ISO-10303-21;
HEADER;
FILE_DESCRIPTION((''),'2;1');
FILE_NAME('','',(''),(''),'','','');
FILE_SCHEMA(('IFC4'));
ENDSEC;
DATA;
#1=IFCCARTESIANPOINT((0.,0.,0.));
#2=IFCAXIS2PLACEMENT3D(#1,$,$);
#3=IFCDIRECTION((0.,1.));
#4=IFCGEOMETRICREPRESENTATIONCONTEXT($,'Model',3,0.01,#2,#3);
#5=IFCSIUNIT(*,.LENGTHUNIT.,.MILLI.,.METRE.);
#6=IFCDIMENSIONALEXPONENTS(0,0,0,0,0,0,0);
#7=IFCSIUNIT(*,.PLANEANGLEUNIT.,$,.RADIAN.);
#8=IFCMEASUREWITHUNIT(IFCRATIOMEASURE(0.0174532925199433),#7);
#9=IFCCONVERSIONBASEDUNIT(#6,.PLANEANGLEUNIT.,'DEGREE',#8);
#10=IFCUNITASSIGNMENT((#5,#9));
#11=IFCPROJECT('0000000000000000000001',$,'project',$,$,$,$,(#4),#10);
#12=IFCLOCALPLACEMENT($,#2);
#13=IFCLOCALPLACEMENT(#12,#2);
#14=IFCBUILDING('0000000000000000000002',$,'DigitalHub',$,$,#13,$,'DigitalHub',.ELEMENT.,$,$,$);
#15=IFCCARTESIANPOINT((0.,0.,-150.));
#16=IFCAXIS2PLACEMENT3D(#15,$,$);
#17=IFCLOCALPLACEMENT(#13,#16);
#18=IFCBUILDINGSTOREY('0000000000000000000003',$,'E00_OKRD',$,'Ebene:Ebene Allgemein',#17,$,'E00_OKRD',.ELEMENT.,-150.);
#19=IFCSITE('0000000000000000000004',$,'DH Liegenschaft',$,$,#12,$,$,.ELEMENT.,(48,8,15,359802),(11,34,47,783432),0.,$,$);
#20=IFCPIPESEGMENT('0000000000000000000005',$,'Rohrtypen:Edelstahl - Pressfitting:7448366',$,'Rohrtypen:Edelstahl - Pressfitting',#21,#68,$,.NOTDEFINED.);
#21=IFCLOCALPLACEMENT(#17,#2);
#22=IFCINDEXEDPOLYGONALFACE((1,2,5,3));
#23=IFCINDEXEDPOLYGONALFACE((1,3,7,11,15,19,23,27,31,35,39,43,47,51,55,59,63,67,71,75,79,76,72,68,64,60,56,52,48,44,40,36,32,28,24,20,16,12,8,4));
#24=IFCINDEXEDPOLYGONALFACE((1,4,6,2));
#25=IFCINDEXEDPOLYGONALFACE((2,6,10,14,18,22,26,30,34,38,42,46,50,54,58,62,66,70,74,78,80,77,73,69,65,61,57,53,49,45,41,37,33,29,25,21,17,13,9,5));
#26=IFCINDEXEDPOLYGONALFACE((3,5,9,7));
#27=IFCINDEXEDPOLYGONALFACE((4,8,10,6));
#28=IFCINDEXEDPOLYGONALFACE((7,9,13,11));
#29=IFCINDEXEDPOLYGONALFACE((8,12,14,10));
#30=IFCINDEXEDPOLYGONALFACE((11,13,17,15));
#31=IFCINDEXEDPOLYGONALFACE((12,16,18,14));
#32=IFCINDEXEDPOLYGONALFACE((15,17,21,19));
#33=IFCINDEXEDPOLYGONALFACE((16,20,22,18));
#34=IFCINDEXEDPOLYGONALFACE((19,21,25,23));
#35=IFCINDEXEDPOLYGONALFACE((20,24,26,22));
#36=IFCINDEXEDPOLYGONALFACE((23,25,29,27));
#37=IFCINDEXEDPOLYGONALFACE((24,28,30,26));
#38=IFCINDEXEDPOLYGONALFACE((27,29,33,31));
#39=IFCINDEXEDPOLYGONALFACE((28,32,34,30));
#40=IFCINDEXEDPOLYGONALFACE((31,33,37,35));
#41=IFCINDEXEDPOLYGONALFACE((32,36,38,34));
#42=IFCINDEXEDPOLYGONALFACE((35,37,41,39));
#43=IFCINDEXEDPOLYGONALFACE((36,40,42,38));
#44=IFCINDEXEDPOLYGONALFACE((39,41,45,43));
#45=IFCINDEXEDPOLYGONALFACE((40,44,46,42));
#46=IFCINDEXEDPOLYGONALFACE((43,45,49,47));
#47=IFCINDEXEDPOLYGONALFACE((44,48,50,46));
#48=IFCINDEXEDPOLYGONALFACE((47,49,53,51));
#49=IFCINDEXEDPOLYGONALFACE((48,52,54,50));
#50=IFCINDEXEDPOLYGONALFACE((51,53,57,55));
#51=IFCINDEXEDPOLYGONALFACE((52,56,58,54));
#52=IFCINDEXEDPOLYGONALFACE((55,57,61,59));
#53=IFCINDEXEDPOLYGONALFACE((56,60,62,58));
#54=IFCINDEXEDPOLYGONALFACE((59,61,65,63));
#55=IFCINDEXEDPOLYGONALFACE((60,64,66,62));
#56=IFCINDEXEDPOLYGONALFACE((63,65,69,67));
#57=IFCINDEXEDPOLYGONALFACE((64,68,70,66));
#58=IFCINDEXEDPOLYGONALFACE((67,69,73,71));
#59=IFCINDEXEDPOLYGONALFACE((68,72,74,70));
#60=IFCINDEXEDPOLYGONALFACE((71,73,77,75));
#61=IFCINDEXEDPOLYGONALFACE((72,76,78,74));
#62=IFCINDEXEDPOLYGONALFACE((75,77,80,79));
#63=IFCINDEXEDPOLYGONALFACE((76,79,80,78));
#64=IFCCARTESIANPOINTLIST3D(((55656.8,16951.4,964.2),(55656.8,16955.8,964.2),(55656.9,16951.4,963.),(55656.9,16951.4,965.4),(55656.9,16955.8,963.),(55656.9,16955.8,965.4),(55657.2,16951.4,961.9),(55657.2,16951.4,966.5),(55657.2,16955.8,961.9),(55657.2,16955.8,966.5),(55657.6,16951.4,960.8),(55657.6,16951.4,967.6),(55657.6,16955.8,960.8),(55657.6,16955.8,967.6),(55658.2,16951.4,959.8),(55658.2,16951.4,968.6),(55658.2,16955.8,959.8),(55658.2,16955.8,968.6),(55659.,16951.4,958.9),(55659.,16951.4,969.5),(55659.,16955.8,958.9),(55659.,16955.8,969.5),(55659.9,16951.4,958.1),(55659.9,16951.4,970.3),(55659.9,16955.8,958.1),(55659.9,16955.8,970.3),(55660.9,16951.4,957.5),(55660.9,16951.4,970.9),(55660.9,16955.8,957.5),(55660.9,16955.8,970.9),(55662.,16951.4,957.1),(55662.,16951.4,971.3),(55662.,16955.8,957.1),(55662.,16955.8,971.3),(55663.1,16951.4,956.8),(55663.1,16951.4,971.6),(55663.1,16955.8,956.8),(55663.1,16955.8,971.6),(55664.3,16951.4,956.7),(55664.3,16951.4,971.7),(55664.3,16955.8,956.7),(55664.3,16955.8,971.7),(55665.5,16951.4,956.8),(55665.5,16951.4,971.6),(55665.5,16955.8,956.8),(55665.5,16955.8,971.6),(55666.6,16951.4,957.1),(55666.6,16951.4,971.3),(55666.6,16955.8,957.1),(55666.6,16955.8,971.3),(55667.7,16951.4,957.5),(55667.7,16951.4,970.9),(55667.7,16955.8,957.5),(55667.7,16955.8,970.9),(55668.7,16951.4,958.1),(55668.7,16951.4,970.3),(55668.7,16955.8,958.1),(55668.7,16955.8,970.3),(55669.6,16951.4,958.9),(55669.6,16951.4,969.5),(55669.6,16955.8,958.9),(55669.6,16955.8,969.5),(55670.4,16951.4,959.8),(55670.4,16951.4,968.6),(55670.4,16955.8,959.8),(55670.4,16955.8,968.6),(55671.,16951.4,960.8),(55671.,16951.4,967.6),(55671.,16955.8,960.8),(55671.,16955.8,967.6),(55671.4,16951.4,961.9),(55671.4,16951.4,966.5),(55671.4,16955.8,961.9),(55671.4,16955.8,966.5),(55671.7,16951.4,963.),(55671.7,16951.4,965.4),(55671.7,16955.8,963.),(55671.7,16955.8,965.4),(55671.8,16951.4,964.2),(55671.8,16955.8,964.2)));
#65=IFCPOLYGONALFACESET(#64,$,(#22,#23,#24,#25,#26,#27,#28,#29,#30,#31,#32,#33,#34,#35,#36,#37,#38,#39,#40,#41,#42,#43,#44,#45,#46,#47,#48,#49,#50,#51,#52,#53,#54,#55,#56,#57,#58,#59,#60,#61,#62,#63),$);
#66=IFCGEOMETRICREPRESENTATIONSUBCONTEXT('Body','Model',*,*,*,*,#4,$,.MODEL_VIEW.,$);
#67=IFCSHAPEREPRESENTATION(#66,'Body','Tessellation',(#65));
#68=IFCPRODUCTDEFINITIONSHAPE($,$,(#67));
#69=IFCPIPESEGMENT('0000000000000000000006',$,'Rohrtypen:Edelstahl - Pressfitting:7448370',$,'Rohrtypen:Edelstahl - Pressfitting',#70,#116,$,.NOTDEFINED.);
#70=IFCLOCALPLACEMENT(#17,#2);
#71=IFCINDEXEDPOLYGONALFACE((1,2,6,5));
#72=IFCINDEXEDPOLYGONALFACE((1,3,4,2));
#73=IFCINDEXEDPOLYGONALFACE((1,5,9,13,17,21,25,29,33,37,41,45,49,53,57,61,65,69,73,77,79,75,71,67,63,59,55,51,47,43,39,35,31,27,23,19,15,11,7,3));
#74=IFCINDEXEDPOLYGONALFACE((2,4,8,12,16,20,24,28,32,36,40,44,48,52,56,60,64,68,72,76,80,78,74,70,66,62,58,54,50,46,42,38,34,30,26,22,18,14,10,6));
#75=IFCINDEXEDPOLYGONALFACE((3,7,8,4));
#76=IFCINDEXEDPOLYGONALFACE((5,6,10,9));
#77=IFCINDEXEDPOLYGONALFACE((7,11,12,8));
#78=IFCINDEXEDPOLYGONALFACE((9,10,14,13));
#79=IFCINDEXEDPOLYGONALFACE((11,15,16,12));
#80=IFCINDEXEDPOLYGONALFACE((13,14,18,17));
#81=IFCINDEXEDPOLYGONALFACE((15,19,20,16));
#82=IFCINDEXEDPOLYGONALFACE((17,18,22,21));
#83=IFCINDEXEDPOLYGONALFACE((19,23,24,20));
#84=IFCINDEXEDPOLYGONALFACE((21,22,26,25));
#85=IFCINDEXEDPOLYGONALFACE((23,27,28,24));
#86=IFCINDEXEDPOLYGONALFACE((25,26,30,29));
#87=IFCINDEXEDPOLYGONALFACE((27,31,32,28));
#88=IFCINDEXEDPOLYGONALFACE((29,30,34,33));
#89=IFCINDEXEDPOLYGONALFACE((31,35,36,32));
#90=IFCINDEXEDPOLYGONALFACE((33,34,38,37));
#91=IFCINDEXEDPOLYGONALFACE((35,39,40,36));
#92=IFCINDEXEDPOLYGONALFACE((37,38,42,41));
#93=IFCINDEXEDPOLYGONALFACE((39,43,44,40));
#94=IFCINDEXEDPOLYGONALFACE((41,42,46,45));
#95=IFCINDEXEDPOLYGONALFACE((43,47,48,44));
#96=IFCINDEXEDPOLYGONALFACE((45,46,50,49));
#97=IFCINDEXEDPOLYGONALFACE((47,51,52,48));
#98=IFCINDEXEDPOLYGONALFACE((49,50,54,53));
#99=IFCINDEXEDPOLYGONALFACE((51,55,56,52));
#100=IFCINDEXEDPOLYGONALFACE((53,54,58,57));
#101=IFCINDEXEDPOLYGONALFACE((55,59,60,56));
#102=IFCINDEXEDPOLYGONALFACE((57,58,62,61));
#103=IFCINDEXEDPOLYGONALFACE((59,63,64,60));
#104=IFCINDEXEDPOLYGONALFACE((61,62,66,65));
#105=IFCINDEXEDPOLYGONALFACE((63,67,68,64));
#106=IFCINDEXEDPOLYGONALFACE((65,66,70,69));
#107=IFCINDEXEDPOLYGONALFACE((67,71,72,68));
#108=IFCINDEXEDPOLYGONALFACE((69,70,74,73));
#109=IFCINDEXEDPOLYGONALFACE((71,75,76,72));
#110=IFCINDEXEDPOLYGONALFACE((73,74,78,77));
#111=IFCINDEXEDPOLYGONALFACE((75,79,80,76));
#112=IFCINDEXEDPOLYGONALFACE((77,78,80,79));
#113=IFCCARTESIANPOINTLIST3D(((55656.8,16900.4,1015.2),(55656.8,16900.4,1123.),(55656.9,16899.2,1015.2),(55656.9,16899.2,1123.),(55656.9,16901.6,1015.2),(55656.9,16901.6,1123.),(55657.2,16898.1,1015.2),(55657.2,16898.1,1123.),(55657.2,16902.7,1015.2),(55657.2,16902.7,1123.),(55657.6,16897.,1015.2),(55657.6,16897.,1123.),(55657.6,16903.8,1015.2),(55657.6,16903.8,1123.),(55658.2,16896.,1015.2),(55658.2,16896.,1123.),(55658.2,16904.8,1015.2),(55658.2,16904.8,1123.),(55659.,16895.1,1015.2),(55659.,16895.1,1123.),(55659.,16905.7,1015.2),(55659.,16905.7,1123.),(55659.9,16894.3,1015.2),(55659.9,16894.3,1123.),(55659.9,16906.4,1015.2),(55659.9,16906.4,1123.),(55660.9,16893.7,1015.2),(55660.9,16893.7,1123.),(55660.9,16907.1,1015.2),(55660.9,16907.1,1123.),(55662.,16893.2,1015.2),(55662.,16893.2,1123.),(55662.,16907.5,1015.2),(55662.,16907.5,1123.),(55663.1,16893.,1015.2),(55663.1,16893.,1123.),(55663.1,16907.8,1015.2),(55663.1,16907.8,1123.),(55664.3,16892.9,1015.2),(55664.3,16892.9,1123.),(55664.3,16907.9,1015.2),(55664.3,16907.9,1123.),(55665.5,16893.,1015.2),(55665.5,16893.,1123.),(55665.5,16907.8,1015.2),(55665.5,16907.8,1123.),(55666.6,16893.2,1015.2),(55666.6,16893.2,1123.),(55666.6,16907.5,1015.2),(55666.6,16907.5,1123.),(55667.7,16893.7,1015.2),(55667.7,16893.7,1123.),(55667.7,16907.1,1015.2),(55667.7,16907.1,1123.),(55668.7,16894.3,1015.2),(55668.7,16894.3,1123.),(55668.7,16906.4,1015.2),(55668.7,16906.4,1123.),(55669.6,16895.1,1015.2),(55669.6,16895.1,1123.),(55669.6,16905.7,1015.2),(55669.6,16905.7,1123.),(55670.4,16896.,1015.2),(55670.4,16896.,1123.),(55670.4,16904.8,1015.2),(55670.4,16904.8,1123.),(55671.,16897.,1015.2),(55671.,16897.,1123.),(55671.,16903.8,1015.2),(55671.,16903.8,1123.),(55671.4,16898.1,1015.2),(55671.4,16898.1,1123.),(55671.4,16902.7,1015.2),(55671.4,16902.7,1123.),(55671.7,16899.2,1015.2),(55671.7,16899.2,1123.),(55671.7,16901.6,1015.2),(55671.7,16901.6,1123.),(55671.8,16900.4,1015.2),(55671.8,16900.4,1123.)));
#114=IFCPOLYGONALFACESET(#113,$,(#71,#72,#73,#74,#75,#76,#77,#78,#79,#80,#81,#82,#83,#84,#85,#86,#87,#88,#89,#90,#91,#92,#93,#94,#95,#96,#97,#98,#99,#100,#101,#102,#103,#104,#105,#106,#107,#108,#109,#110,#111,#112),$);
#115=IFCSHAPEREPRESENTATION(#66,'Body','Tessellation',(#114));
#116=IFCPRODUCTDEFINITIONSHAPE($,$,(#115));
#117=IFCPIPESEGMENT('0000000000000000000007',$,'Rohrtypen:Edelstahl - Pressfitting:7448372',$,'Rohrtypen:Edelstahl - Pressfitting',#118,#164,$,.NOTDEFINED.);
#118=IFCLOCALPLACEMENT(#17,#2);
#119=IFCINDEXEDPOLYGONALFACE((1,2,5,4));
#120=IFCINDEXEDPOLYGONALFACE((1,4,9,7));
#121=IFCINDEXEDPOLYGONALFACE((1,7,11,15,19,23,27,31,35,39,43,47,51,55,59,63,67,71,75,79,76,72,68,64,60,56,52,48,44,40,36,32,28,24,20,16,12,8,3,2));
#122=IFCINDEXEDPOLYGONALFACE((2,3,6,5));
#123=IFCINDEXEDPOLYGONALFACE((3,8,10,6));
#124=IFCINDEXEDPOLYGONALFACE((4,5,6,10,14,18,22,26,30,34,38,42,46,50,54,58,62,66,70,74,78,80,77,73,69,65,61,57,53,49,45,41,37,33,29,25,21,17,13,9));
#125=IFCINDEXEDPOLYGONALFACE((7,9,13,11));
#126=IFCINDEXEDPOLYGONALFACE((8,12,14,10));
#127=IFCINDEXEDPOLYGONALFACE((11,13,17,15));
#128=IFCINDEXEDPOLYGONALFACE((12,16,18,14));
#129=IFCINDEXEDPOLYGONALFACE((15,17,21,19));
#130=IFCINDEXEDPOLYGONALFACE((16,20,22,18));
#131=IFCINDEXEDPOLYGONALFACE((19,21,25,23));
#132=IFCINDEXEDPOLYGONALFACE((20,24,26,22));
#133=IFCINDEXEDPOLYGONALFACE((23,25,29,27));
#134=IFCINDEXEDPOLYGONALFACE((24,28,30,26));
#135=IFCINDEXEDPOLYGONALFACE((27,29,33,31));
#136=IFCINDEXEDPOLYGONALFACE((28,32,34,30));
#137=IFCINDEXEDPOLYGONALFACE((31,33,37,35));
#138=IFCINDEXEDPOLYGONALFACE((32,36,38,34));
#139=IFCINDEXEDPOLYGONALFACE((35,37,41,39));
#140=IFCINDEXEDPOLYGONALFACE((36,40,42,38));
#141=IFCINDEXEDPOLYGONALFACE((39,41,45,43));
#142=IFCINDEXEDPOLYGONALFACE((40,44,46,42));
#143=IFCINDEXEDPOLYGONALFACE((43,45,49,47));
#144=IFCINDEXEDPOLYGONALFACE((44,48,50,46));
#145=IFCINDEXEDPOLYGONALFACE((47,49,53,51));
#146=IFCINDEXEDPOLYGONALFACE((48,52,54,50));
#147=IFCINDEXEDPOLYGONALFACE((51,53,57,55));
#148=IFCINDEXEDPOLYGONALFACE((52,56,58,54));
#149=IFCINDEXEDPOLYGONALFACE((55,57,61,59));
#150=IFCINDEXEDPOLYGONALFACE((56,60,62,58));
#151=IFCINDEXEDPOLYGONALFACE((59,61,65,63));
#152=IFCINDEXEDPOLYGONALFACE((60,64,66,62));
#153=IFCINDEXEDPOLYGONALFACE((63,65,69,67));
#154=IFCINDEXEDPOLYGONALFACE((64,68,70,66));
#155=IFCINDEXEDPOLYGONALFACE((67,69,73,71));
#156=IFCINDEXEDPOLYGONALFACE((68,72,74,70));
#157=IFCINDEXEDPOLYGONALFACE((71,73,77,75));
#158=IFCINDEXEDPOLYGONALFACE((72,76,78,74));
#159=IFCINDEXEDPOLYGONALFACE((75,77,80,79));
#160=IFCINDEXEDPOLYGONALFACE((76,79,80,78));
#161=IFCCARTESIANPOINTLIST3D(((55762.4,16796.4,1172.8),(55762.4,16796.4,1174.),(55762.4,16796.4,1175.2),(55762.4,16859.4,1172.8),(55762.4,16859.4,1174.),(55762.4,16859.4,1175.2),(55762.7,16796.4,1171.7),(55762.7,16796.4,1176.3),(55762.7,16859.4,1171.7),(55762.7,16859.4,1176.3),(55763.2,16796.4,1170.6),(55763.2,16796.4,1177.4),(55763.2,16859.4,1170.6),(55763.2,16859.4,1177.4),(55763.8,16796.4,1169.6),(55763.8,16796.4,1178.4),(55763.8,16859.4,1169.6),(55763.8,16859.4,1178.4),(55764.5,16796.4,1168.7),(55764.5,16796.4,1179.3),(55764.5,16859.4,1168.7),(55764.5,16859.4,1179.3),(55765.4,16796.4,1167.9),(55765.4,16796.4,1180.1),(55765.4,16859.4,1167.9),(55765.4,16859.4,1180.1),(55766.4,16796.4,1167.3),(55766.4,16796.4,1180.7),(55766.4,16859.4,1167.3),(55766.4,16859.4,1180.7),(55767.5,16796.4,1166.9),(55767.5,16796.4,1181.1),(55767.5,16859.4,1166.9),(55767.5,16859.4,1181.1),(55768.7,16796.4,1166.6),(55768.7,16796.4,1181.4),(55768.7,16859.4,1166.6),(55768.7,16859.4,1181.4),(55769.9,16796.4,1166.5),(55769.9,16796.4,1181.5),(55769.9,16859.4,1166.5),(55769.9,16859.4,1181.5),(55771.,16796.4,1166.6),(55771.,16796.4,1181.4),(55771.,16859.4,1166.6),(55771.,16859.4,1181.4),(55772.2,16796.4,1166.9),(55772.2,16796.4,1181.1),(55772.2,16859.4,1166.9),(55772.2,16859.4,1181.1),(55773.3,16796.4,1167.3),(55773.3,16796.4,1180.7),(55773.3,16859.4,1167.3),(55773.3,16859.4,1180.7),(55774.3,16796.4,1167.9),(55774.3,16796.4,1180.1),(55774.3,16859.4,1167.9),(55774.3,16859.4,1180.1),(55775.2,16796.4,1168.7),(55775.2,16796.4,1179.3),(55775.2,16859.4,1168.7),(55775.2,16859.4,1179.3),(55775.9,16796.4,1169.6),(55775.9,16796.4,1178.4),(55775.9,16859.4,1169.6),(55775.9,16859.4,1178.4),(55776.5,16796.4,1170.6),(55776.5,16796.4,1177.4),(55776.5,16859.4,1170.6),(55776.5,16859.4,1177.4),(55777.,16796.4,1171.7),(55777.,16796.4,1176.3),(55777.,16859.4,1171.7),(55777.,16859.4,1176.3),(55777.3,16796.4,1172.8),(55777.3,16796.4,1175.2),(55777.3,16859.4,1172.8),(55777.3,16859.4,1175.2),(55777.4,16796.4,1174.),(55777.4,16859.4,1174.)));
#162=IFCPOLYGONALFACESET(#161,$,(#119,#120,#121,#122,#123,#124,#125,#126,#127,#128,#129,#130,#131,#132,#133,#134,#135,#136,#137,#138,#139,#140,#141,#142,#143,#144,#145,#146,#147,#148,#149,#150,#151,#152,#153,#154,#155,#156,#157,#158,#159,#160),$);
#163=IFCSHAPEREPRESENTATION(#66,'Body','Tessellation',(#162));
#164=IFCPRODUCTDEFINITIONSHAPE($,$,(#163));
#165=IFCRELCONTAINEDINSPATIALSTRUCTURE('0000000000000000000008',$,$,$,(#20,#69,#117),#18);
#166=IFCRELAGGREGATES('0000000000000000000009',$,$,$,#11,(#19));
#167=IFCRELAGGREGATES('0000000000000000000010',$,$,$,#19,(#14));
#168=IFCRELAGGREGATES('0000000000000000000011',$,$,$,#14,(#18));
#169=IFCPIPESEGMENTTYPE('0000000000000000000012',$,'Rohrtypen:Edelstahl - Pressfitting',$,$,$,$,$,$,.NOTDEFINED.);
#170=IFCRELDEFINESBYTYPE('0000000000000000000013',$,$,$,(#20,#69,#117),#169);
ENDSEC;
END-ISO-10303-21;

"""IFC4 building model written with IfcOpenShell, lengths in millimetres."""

from ifc_helpers import new_model, entity, si_unit, converted_unit, direction, frame, origin, place, context, subcontext, project, spatial, indexed_curve, outline, extrude, type_object, element, save


model = new_model("IFC4")

# Units and contexts
model_context = context("Model", 3, precision=0.01, world=origin(), true_north=direction((0.0, 1.0)))
body_context = subcontext(model_context, "Body", "Model", "MODEL_VIEW")
ifc_project = project(units=[si_unit("LENGTHUNIT", "METRE", prefix="MILLI"), converted_unit("PLANEANGLEUNIT", "DEGREE", entity("IfcRatioMeasure", 0.0174532925199433), si_unit("PLANEANGLEUNIT", "RADIAN"), dimensions=[0, 0, 0, 0, 0, 0, 0])], contexts=[model_context])

# Site, building, storey
site_placement = place(None, origin())
site = spatial("IfcSite", under=ifc_project, at=site_placement, Name="DH Liegenschaft", CompositionType="ELEMENT", RefLatitude=(48, 8, 15, 359802), RefLongitude=(11, 34, 47, 783432), RefElevation=0.0)
building_placement = place(site_placement, origin())
building = spatial("IfcBuilding", under=site, at=building_placement, Name="DigitalHub", LongName="DigitalHub", CompositionType="ELEMENT")
storey_placement = place(building_placement, frame((0.0, 0.0, -150.0)))
storey = spatial("IfcBuildingStorey", under=building, at=storey_placement, Name="E00_OKRD", ObjectType="Ebene:Ebene Allgemein", LongName="E00_OKRD", CompositionType="ELEMENT", Elevation=-150.0)

# Pipe segments
pipe_segment_type_1 = type_object("IfcPipeSegmentType", Name="Rohrtypen:Edelstahl - Pressfitting", PredefinedType="NOTDEFINED")
pipe_segment_1_placement = place(storey_placement, frame((55655.2, 16951.4, 955.1)))
element("IfcPipeSegment", 1, at=pipe_segment_1_placement, inside=storey, type_object=pipe_segment_type_1, Name="Rohrtypen:Edelstahl - Pressfitting:7448366", ObjectType="Rohrtypen:Edelstahl - Pressfitting", PredefinedType="NOTDEFINED", context=body_context, shape_type="SweptSolid", body=[
    extrude(outline(indexed_curve([(7.5, 0.0), (7.4, 1.2), (7.1, 2.3), (6.7, 3.4), (6.1, 4.4), (5.3, 5.3), (4.4, 6.1), (3.4, 6.7), (2.3, 7.1), (1.2, 7.4), (0.0, 7.5), (-1.2, 7.4), (-2.3, 7.1), (-3.4, 6.7), (-4.4, 6.1), (-5.3, 5.3), (-6.1, 4.4), (-6.7, 3.4), (-7.1, 2.3), (-7.4, 1.2), (-7.5, 0.0), (-7.4, -1.2), (-7.1, -2.3), (-6.7, -3.4), (-6.1, -4.4), (-5.3, -5.3), (-4.4, -6.1), (-3.4, -6.7), (-2.3, -7.1), (-1.2, -7.4), (0.0, -7.5), (1.2, -7.4), (2.3, -7.1), (3.4, -6.7), (4.4, -6.1), (5.3, -5.3), (6.1, -4.4), (6.7, -3.4), (7.1, -2.3), (7.4, -1.2), (7.5, 0.0)], self_intersect=False)), frame((9.1, 0.0, 9.1), z_axis=(0.0, 1.0, 0.0), x_axis=(-1.0, 0.0, 0.0)), (0.0, 0.0, 1.0), 4.4),
])
pipe_segment_2_placement = place(storey_placement, frame((55655.2, 16891.3, 1015.2)))
element("IfcPipeSegment", 2, at=pipe_segment_2_placement, inside=storey, type_object=pipe_segment_type_1, Name="Rohrtypen:Edelstahl - Pressfitting:7448370", ObjectType="Rohrtypen:Edelstahl - Pressfitting", PredefinedType="NOTDEFINED", context=body_context, shape_type="SweptSolid", body=[
    extrude(outline(indexed_curve([(7.5, 0.0), (7.4, 1.2), (7.1, 2.3), (6.7, 3.4), (6.1, 4.4), (5.3, 5.3), (4.4, 6.1), (3.4, 6.7), (2.3, 7.1), (1.2, 7.4), (0.0, 7.5), (-1.2, 7.4), (-2.3, 7.1), (-3.4, 6.7), (-4.4, 6.1), (-5.3, 5.3), (-6.1, 4.4), (-6.7, 3.4), (-7.1, 2.3), (-7.4, 1.2), (-7.5, 0.0), (-7.4, -1.2), (-7.1, -2.3), (-6.7, -3.4), (-6.1, -4.4), (-5.3, -5.3), (-4.4, -6.1), (-3.4, -6.7), (-2.3, -7.1), (-1.2, -7.4), (0.0, -7.5), (1.2, -7.4), (2.3, -7.1), (3.4, -6.7), (4.4, -6.1), (5.3, -5.3), (6.1, -4.4), (6.7, -3.4), (7.1, -2.3), (7.4, -1.2), (7.5, 0.0)], self_intersect=False)), frame((9.1, 9.1, 0.0), z_axis=(0.0, 0.0, 1.0), x_axis=(-1.0, 0.0, 0.0)), (0.0, 0.0, 1.0), 107.8),
])
pipe_segment_3_placement = place(storey_placement, frame((55760.8, 16796.4, 1164.9)))
element("IfcPipeSegment", 3, at=pipe_segment_3_placement, inside=storey, type_object=pipe_segment_type_1, Name="Rohrtypen:Edelstahl - Pressfitting:7448372", ObjectType="Rohrtypen:Edelstahl - Pressfitting", PredefinedType="NOTDEFINED", context=body_context, shape_type="SweptSolid", body=[
    extrude(outline(indexed_curve([(7.5, 0.0), (7.4, 1.2), (7.1, 2.3), (6.7, 3.4), (6.1, 4.4), (5.3, 5.3), (4.4, 6.1), (3.4, 6.7), (2.3, 7.1), (1.2, 7.4), (0.0, 7.5), (-1.2, 7.4), (-2.3, 7.1), (-3.4, 6.7), (-4.4, 6.1), (-5.3, 5.3), (-6.1, 4.4), (-6.7, 3.4), (-7.1, 2.3), (-7.4, 1.2), (-7.5, 0.0), (-7.4, -1.2), (-7.1, -2.3), (-6.7, -3.4), (-6.1, -4.4), (-5.3, -5.3), (-4.4, -6.1), (-3.4, -6.7), (-2.3, -7.1), (-1.2, -7.4), (0.0, -7.5), (1.2, -7.4), (2.3, -7.1), (3.4, -6.7), (4.4, -6.1), (5.3, -5.3), (6.1, -4.4), (6.7, -3.4), (7.1, -2.3), (7.4, -1.2), (7.5, 0.0)], self_intersect=False)), frame((9.1, 0.0, 9.1), z_axis=(0.0, 1.0, 0.0), x_axis=(-1.0, 0.0, 0.0)), (0.0, 0.0, 1.0), 63.0),
])

save(model, "model.ifc")
